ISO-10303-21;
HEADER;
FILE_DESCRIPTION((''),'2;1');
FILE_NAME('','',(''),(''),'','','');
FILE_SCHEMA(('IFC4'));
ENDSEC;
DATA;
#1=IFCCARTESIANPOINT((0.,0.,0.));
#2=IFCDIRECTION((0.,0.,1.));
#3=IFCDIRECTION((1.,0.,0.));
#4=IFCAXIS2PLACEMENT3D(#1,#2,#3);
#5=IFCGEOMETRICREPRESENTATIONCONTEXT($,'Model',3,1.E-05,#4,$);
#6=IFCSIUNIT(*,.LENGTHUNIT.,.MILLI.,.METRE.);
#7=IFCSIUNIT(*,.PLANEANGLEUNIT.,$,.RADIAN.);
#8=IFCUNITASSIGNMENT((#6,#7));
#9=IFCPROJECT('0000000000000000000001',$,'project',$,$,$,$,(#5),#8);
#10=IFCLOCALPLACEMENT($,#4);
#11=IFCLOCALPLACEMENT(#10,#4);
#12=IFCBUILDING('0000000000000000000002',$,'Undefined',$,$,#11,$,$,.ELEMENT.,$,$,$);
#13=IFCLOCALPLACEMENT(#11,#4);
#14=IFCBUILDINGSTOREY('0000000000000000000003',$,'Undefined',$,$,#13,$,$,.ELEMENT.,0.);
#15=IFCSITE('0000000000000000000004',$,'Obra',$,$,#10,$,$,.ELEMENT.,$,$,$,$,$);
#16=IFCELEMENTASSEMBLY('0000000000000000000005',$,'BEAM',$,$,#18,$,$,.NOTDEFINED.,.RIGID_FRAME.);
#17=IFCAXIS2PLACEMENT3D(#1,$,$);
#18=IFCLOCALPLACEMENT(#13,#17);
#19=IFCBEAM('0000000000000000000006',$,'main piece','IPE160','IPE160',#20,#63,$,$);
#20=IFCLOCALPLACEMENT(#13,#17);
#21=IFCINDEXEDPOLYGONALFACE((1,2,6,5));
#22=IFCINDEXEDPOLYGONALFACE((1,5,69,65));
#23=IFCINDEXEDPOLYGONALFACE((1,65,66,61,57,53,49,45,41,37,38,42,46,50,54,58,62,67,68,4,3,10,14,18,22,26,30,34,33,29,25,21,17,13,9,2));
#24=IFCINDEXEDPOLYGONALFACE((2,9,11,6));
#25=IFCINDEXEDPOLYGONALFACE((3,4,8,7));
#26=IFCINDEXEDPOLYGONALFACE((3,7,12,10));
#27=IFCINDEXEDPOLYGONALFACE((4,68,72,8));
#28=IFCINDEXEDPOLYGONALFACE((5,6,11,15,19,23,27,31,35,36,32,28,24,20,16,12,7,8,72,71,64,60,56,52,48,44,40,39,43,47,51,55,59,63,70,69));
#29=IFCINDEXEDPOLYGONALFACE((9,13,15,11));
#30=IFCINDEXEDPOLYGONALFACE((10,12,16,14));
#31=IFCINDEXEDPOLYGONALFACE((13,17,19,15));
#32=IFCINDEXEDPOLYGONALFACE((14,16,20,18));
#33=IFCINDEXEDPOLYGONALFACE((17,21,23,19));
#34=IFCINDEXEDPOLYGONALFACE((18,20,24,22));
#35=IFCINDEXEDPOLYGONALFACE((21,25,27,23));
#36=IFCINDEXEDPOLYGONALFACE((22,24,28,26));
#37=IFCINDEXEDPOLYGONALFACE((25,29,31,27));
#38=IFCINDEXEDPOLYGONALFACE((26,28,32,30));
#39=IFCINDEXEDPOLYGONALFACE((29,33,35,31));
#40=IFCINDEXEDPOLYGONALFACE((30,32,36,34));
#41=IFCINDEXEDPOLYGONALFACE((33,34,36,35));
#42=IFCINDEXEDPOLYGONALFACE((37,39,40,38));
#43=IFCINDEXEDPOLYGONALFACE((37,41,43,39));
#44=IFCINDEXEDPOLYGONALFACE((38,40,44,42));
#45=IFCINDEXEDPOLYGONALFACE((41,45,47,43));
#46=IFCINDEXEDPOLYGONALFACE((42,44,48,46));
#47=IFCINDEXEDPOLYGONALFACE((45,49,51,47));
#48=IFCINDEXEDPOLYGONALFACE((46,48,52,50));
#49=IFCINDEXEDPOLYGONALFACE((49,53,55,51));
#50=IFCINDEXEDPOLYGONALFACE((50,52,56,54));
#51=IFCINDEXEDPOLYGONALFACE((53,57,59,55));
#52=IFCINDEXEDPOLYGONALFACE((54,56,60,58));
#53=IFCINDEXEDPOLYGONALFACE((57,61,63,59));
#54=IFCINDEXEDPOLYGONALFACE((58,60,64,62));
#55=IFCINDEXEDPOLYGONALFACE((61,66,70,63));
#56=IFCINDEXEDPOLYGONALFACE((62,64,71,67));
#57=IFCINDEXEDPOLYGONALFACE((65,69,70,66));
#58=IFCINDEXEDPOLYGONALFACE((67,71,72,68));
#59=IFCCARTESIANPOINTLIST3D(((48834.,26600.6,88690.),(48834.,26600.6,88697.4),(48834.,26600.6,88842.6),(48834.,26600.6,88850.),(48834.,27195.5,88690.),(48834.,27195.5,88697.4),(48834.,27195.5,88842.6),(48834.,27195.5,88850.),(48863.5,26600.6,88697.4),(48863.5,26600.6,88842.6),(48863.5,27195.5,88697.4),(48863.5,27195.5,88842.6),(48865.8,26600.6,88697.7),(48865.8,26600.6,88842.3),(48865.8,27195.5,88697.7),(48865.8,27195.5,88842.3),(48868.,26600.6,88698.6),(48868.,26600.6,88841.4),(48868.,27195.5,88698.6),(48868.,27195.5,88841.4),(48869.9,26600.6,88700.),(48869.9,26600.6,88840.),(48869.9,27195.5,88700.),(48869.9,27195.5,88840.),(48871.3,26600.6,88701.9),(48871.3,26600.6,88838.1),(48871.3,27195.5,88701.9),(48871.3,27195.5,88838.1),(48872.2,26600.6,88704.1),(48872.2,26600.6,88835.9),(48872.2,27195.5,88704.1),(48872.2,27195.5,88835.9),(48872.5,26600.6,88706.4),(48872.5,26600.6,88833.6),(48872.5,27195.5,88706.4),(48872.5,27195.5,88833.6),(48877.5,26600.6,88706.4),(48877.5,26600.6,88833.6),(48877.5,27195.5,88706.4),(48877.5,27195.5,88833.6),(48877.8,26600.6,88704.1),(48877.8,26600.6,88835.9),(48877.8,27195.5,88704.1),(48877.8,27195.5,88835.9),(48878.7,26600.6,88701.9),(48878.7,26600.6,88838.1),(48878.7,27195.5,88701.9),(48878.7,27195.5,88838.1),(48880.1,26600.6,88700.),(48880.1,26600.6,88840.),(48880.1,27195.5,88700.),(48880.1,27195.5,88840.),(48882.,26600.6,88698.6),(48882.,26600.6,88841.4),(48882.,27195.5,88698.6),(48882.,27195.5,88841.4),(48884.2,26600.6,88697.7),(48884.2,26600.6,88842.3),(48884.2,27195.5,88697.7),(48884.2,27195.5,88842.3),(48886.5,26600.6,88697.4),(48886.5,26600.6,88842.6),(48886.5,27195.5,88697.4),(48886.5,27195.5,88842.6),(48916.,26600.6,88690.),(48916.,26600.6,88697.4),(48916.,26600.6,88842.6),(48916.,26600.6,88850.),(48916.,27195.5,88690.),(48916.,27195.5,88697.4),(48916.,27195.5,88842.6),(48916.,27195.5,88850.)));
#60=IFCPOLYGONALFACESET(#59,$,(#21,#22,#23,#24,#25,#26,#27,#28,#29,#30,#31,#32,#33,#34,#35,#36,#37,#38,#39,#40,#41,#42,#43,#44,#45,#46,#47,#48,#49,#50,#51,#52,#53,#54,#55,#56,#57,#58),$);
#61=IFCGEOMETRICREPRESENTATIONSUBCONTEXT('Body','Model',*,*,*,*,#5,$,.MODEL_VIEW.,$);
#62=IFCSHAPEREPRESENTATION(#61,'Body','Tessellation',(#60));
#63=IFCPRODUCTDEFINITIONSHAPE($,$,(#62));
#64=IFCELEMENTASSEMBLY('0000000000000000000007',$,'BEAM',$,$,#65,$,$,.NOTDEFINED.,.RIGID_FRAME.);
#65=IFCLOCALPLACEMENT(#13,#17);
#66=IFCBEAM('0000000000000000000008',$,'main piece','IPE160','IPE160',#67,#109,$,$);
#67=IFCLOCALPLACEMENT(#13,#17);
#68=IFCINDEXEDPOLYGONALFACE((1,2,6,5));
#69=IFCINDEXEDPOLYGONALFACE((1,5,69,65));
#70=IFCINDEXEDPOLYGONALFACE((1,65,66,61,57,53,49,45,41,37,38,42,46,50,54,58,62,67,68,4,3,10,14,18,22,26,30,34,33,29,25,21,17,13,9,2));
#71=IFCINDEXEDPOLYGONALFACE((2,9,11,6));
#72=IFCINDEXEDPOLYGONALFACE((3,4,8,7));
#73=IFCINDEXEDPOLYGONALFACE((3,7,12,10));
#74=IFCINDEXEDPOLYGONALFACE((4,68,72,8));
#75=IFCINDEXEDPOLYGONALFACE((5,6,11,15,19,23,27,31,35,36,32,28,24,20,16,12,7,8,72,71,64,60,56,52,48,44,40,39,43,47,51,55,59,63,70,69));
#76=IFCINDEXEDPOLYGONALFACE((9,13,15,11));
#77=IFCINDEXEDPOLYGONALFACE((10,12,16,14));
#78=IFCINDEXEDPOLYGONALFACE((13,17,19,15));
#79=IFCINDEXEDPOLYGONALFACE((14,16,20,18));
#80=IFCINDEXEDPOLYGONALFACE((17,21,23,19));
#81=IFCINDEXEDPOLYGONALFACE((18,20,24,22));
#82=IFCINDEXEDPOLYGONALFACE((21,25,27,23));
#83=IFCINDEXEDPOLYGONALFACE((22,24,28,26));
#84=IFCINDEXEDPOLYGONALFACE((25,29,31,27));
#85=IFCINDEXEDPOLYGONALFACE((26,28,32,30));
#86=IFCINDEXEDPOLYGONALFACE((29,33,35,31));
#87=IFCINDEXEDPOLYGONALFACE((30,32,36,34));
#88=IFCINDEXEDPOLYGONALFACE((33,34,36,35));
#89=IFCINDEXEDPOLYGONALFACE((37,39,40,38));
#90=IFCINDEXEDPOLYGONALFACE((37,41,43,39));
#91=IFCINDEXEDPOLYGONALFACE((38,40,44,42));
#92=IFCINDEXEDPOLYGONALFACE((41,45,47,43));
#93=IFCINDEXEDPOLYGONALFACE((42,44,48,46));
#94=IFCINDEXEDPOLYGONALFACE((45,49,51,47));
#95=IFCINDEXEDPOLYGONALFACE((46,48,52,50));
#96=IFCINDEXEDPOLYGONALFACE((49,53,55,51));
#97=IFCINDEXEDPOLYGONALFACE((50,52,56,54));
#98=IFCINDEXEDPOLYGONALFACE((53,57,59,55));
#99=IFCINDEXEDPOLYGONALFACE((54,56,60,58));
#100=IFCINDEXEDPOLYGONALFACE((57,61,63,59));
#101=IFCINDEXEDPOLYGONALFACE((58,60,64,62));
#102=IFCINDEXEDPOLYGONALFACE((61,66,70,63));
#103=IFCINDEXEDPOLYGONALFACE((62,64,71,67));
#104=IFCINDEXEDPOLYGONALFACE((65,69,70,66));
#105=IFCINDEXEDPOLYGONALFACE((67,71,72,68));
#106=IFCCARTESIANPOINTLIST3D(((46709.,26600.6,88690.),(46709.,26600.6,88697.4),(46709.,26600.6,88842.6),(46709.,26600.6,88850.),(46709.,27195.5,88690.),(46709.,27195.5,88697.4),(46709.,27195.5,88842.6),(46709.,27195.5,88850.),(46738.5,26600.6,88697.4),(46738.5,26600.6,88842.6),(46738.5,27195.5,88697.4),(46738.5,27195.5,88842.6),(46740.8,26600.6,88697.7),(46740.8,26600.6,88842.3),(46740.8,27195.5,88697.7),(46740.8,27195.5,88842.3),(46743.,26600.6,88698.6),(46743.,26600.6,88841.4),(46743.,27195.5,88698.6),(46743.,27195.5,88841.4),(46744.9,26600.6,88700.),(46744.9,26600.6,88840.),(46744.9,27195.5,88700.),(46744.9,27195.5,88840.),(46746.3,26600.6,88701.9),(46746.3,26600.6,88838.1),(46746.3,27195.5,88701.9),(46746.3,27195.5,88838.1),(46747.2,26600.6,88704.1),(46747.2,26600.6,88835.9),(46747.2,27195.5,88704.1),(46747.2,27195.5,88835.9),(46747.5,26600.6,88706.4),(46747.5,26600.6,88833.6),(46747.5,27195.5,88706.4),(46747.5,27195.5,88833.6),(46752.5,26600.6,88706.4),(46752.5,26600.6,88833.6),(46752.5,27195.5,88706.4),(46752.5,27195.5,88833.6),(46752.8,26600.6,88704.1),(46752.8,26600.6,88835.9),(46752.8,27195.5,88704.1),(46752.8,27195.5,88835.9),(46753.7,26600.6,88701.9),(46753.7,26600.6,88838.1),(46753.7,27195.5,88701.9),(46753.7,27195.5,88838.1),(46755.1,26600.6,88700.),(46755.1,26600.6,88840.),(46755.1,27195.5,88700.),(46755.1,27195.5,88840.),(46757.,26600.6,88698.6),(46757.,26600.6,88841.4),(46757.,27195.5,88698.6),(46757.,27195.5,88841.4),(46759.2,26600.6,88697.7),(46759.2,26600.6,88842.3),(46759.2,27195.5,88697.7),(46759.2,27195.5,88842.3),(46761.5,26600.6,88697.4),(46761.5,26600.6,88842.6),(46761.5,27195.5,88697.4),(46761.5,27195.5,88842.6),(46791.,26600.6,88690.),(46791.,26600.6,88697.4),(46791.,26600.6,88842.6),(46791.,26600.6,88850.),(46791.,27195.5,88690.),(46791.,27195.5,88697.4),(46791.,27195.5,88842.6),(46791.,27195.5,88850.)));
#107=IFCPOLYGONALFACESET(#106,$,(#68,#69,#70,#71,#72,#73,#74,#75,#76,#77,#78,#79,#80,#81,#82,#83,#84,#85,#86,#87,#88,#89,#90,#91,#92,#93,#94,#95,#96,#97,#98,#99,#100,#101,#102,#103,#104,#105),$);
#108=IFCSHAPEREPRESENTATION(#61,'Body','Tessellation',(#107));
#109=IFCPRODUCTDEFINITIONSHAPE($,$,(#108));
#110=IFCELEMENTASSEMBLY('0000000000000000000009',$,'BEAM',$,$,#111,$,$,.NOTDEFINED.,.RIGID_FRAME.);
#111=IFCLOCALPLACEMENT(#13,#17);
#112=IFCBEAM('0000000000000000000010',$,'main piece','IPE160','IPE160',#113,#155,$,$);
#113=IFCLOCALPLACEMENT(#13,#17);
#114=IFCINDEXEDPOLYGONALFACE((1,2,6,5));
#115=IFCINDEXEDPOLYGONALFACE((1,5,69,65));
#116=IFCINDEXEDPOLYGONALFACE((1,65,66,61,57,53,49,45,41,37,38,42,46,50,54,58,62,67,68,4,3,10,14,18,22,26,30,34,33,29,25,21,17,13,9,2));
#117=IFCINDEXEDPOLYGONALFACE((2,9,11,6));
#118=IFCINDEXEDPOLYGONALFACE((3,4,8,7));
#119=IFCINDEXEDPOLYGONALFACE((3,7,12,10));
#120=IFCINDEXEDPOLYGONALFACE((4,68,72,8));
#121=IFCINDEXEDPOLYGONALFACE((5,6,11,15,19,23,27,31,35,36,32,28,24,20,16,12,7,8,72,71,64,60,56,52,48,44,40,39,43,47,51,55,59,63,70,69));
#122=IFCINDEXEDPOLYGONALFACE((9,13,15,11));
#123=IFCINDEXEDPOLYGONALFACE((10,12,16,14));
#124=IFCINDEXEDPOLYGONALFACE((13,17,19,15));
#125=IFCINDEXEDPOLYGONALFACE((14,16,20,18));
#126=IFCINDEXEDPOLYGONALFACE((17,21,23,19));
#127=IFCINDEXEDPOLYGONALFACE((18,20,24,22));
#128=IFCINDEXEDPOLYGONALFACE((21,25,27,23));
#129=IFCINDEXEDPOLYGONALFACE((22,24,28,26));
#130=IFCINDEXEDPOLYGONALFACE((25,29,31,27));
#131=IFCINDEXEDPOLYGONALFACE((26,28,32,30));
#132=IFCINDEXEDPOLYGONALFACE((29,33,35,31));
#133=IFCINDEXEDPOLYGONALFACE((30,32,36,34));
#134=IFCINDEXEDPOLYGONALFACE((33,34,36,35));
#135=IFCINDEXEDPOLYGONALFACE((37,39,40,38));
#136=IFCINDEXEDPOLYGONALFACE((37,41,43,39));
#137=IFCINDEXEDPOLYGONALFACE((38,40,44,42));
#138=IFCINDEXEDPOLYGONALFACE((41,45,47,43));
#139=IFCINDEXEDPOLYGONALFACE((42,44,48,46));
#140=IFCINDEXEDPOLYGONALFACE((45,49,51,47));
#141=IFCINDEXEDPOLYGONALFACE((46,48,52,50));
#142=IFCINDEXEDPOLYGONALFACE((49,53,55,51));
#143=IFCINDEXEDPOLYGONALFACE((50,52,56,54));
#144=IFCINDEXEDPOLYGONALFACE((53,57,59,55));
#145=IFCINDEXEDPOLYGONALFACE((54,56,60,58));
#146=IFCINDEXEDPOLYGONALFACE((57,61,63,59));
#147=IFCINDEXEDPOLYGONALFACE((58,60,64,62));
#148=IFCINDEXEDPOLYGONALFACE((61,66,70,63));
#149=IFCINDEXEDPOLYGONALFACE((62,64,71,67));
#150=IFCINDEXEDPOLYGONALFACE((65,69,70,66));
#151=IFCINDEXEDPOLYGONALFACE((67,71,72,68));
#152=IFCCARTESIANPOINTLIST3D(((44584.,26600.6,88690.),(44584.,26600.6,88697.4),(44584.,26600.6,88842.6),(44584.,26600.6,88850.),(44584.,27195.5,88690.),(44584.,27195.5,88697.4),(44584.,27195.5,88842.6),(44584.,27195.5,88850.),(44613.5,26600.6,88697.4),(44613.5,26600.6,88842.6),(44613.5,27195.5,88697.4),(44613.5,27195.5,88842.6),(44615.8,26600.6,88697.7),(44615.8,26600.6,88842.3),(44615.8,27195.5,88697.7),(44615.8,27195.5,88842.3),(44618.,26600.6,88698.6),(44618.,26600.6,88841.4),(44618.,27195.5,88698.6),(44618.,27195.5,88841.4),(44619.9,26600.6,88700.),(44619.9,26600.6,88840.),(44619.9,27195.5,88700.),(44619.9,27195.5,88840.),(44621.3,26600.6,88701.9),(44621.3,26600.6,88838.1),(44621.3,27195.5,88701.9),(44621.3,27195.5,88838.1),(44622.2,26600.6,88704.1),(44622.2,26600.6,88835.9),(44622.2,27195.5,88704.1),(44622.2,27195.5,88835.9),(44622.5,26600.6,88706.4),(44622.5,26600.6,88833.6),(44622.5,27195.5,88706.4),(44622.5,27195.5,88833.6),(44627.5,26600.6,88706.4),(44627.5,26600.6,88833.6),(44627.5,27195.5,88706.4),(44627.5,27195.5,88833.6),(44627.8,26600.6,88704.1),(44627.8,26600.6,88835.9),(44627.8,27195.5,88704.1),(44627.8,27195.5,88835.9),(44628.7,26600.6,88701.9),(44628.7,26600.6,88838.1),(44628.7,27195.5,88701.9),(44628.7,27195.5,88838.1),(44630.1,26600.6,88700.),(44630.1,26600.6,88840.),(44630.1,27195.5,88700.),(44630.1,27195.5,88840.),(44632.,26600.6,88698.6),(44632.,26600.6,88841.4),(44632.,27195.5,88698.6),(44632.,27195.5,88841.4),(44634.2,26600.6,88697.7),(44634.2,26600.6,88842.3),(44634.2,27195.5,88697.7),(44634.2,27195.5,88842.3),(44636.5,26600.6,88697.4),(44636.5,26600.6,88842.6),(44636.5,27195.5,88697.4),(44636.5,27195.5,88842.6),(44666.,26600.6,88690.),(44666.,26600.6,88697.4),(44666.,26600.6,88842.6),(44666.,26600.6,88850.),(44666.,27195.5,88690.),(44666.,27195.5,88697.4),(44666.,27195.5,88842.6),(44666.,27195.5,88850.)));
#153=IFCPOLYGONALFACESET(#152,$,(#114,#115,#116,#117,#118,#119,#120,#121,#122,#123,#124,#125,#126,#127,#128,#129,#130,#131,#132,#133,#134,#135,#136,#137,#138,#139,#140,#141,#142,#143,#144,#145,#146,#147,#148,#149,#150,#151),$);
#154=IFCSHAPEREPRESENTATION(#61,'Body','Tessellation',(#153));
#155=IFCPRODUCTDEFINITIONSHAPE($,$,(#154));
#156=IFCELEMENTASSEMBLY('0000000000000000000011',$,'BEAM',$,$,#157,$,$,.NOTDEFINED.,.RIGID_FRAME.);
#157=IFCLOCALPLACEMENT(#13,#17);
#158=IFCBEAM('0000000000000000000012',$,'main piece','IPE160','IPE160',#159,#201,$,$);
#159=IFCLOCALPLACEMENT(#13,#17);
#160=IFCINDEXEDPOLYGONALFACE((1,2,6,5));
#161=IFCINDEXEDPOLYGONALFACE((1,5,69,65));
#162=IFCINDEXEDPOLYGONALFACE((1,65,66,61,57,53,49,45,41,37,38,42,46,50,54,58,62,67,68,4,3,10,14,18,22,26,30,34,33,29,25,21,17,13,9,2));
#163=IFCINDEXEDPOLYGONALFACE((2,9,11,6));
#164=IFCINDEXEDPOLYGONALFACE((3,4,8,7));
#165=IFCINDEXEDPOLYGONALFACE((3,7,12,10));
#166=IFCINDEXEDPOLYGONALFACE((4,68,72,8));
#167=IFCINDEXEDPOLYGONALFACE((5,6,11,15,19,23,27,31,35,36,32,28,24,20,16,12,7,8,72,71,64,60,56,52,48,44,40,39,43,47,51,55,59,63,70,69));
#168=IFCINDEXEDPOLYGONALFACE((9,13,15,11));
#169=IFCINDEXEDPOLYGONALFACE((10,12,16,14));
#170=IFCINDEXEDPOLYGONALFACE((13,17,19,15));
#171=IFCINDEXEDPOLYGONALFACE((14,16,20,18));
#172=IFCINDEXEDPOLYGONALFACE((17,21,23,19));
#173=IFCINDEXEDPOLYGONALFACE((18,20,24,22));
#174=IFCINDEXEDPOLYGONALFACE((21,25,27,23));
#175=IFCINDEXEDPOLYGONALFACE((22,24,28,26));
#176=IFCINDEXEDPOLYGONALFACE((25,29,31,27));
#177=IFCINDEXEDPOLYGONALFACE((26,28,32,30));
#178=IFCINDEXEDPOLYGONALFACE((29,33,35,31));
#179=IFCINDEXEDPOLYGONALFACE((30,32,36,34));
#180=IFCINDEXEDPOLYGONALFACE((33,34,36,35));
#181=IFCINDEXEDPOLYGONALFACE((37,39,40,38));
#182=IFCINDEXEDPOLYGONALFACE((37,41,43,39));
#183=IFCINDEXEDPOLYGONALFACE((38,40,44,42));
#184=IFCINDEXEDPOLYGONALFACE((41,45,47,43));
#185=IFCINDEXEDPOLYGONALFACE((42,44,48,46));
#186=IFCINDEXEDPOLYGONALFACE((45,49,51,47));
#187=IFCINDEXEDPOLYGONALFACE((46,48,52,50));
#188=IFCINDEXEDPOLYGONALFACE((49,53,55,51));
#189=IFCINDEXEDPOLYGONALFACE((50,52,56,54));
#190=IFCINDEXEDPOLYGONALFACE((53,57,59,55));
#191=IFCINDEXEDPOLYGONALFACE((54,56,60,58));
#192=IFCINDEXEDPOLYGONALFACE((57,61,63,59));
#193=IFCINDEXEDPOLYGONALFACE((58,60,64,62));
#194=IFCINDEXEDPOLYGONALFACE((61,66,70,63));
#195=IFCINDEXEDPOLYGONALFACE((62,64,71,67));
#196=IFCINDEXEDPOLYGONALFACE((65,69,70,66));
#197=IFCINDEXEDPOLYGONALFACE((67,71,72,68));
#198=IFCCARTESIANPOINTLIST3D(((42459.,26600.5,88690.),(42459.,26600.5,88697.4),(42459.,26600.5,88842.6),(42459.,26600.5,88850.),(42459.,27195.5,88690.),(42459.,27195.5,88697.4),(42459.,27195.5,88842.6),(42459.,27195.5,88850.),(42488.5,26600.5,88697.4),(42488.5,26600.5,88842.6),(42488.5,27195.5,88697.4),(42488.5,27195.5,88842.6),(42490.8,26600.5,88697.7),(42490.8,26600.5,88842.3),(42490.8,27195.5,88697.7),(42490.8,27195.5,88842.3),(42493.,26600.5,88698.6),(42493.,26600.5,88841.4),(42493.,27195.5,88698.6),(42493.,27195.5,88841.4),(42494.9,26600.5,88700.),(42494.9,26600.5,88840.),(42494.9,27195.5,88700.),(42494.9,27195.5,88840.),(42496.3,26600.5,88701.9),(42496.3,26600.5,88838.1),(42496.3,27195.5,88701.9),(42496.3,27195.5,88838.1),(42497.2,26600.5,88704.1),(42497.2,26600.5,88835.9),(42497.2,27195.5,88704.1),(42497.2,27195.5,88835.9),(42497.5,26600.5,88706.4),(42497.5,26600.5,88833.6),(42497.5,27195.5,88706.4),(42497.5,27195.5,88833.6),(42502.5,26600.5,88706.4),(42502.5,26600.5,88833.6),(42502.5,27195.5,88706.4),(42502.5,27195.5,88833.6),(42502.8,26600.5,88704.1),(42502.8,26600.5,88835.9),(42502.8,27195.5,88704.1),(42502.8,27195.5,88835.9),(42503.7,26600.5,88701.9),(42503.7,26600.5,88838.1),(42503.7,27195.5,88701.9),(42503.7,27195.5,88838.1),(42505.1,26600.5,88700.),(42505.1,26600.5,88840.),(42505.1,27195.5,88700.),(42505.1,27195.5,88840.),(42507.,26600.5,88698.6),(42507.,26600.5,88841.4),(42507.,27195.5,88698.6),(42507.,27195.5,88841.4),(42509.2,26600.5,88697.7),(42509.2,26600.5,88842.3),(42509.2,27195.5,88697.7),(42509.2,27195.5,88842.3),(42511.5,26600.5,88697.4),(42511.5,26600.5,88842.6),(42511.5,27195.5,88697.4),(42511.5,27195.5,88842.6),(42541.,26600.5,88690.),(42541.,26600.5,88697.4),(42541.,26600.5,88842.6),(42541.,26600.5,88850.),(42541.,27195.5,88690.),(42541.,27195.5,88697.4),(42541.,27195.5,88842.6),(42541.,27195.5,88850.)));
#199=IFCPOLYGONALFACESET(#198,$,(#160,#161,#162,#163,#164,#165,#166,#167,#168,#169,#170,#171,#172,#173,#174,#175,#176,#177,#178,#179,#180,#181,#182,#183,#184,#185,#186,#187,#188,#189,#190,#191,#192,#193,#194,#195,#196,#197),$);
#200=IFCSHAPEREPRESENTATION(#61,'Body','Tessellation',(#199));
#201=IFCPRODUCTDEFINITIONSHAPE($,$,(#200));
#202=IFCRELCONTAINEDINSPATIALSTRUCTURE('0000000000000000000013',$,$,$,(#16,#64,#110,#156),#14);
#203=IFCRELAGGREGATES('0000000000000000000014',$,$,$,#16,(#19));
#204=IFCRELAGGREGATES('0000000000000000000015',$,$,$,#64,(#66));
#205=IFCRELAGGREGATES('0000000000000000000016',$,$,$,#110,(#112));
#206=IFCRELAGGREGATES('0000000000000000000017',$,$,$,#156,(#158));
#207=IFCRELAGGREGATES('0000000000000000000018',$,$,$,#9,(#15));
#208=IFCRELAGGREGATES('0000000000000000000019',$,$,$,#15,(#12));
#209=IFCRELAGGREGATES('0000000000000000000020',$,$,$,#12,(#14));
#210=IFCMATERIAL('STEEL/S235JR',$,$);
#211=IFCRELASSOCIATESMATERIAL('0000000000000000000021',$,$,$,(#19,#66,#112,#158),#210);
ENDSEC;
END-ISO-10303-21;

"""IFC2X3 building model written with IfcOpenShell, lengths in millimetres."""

from ifc_helpers import new_model, si_unit, frame, origin_with_axes, origin_2d_with_axis, place, context, subcontext, project, spatial, i_section, extrude, material, element, aggregate, save


model = new_model("IFC2X3")

# Units and contexts
model_context = context("Model", 3, precision=1e-05, world=origin_with_axes())
body_context = subcontext(model_context, "Body", "Model", "MODEL_VIEW")
ifc_project = project(units=[si_unit("LENGTHUNIT", "METRE", prefix="MILLI"), si_unit("PLANEANGLEUNIT", "RADIAN")], contexts=[model_context])

# Site, building, storey
site_placement = place(None, origin_with_axes())
site = spatial("IfcSite", under=ifc_project, at=site_placement, Name="Obra", CompositionType="ELEMENT")
building_placement = place(site_placement, origin_with_axes())
building = spatial("IfcBuilding", under=site, at=building_placement, Name="Undefined", CompositionType="ELEMENT")
storey_placement = place(building_placement, origin_with_axes())
storey = spatial("IfcBuildingStorey", under=building, at=storey_placement, Name="Undefined", CompositionType="ELEMENT", Elevation=0.0)

# Element assemblies, beams
ifc_material_1 = material(Name="STEEL/S235JR")
assembly_1_placement = place(storey_placement, origin_with_axes())
assembly_1 = element("IfcElementAssembly", 1, at=assembly_1_placement, inside=storey, Name="BEAM", AssemblyPlace="NOTDEFINED", PredefinedType="RIGID_FRAME")
beam_1_placement = place(assembly_1_placement, frame((48875.0, 26600.6, 88770.0), z_axis=(0.0, 0.0, 1.0), x_axis=(0.0, 1.0, 0.0)))
beam_1 = element("IfcBeam", 2, at=beam_1_placement, material=ifc_material_1, Name="main piece", Description="IPE160", ObjectType="IPE160", context=body_context, shape_type="SweptSolid", body=[
    extrude(i_section(OverallWidth=82.0, OverallDepth=160.0, WebThickness=5.0, FlangeThickness=7.4, FilletRadius=9.0, at=origin_2d_with_axis()), frame((594.9, 0.0, 0.0), z_axis=(-1.0, 0.0, 0.0), x_axis=(0.0, -1.0, 0.0)), (0.0, 0.0, 1.0), 594.9),
])
aggregate(assembly_1, [beam_1])
assembly_2_placement = place(storey_placement, origin_with_axes())
assembly_2 = element("IfcElementAssembly", 3, at=assembly_2_placement, inside=storey, Name="BEAM", AssemblyPlace="NOTDEFINED", PredefinedType="RIGID_FRAME")
beam_2_placement = place(assembly_2_placement, frame((46750.0, 26600.6, 88770.0), z_axis=(0.0, 0.0, 1.0), x_axis=(0.0, 1.0, 0.0)))
beam_2 = element("IfcBeam", 4, at=beam_2_placement, material=ifc_material_1, Name="main piece", Description="IPE160", ObjectType="IPE160", context=body_context, shape_type="SweptSolid", body=[
    extrude(i_section(OverallWidth=82.0, OverallDepth=160.0, WebThickness=5.0, FlangeThickness=7.4, FilletRadius=9.0, at=origin_2d_with_axis()), frame((594.9, 0.0, 0.0), z_axis=(-1.0, 0.0, 0.0), x_axis=(0.0, -1.0, 0.0)), (0.0, 0.0, 1.0), 594.9),
])
aggregate(assembly_2, [beam_2])
assembly_3_placement = place(storey_placement, origin_with_axes())
assembly_3 = element("IfcElementAssembly", 5, at=assembly_3_placement, inside=storey, Name="BEAM", AssemblyPlace="NOTDEFINED", PredefinedType="RIGID_FRAME")
beam_3_placement = place(assembly_3_placement, frame((44625.0, 26600.6, 88770.0), z_axis=(0.0, 0.0, 1.0), x_axis=(0.0, 1.0, 0.0)))
beam_3 = element("IfcBeam", 6, at=beam_3_placement, material=ifc_material_1, Name="main piece", Description="IPE160", ObjectType="IPE160", context=body_context, shape_type="SweptSolid", body=[
    extrude(i_section(OverallWidth=82.0, OverallDepth=160.0, WebThickness=5.0, FlangeThickness=7.4, FilletRadius=9.0, at=origin_2d_with_axis()), frame((594.9, 0.0, 0.0), z_axis=(-1.0, 0.0, 0.0), x_axis=(0.0, -1.0, 0.0)), (0.0, 0.0, 1.0), 594.9),
])
aggregate(assembly_3, [beam_3])
assembly_4_placement = place(storey_placement, origin_with_axes())
assembly_4 = element("IfcElementAssembly", 7, at=assembly_4_placement, inside=storey, Name="BEAM", AssemblyPlace="NOTDEFINED", PredefinedType="RIGID_FRAME")
beam_4_placement = place(assembly_4_placement, frame((42500.0, 26600.5, 88770.0), z_axis=(0.0, 0.0, 1.0), x_axis=(0.0, 1.0, 0.0)))
beam_4 = element("IfcBeam", 8, at=beam_4_placement, material=ifc_material_1, Name="main piece", Description="IPE160", ObjectType="IPE160", context=body_context, shape_type="SweptSolid", body=[
    extrude(i_section(OverallWidth=82.0, OverallDepth=160.0, WebThickness=5.0, FlangeThickness=7.4, FilletRadius=9.0, at=origin_2d_with_axis()), frame((595.0, 0.0, 0.0), z_axis=(-1.0, 0.0, 0.0), x_axis=(0.0, -1.0, 0.0)), (0.0, 0.0, 1.0), 595.0),
])
aggregate(assembly_4, [beam_4])

save(model, "model.ifc")
